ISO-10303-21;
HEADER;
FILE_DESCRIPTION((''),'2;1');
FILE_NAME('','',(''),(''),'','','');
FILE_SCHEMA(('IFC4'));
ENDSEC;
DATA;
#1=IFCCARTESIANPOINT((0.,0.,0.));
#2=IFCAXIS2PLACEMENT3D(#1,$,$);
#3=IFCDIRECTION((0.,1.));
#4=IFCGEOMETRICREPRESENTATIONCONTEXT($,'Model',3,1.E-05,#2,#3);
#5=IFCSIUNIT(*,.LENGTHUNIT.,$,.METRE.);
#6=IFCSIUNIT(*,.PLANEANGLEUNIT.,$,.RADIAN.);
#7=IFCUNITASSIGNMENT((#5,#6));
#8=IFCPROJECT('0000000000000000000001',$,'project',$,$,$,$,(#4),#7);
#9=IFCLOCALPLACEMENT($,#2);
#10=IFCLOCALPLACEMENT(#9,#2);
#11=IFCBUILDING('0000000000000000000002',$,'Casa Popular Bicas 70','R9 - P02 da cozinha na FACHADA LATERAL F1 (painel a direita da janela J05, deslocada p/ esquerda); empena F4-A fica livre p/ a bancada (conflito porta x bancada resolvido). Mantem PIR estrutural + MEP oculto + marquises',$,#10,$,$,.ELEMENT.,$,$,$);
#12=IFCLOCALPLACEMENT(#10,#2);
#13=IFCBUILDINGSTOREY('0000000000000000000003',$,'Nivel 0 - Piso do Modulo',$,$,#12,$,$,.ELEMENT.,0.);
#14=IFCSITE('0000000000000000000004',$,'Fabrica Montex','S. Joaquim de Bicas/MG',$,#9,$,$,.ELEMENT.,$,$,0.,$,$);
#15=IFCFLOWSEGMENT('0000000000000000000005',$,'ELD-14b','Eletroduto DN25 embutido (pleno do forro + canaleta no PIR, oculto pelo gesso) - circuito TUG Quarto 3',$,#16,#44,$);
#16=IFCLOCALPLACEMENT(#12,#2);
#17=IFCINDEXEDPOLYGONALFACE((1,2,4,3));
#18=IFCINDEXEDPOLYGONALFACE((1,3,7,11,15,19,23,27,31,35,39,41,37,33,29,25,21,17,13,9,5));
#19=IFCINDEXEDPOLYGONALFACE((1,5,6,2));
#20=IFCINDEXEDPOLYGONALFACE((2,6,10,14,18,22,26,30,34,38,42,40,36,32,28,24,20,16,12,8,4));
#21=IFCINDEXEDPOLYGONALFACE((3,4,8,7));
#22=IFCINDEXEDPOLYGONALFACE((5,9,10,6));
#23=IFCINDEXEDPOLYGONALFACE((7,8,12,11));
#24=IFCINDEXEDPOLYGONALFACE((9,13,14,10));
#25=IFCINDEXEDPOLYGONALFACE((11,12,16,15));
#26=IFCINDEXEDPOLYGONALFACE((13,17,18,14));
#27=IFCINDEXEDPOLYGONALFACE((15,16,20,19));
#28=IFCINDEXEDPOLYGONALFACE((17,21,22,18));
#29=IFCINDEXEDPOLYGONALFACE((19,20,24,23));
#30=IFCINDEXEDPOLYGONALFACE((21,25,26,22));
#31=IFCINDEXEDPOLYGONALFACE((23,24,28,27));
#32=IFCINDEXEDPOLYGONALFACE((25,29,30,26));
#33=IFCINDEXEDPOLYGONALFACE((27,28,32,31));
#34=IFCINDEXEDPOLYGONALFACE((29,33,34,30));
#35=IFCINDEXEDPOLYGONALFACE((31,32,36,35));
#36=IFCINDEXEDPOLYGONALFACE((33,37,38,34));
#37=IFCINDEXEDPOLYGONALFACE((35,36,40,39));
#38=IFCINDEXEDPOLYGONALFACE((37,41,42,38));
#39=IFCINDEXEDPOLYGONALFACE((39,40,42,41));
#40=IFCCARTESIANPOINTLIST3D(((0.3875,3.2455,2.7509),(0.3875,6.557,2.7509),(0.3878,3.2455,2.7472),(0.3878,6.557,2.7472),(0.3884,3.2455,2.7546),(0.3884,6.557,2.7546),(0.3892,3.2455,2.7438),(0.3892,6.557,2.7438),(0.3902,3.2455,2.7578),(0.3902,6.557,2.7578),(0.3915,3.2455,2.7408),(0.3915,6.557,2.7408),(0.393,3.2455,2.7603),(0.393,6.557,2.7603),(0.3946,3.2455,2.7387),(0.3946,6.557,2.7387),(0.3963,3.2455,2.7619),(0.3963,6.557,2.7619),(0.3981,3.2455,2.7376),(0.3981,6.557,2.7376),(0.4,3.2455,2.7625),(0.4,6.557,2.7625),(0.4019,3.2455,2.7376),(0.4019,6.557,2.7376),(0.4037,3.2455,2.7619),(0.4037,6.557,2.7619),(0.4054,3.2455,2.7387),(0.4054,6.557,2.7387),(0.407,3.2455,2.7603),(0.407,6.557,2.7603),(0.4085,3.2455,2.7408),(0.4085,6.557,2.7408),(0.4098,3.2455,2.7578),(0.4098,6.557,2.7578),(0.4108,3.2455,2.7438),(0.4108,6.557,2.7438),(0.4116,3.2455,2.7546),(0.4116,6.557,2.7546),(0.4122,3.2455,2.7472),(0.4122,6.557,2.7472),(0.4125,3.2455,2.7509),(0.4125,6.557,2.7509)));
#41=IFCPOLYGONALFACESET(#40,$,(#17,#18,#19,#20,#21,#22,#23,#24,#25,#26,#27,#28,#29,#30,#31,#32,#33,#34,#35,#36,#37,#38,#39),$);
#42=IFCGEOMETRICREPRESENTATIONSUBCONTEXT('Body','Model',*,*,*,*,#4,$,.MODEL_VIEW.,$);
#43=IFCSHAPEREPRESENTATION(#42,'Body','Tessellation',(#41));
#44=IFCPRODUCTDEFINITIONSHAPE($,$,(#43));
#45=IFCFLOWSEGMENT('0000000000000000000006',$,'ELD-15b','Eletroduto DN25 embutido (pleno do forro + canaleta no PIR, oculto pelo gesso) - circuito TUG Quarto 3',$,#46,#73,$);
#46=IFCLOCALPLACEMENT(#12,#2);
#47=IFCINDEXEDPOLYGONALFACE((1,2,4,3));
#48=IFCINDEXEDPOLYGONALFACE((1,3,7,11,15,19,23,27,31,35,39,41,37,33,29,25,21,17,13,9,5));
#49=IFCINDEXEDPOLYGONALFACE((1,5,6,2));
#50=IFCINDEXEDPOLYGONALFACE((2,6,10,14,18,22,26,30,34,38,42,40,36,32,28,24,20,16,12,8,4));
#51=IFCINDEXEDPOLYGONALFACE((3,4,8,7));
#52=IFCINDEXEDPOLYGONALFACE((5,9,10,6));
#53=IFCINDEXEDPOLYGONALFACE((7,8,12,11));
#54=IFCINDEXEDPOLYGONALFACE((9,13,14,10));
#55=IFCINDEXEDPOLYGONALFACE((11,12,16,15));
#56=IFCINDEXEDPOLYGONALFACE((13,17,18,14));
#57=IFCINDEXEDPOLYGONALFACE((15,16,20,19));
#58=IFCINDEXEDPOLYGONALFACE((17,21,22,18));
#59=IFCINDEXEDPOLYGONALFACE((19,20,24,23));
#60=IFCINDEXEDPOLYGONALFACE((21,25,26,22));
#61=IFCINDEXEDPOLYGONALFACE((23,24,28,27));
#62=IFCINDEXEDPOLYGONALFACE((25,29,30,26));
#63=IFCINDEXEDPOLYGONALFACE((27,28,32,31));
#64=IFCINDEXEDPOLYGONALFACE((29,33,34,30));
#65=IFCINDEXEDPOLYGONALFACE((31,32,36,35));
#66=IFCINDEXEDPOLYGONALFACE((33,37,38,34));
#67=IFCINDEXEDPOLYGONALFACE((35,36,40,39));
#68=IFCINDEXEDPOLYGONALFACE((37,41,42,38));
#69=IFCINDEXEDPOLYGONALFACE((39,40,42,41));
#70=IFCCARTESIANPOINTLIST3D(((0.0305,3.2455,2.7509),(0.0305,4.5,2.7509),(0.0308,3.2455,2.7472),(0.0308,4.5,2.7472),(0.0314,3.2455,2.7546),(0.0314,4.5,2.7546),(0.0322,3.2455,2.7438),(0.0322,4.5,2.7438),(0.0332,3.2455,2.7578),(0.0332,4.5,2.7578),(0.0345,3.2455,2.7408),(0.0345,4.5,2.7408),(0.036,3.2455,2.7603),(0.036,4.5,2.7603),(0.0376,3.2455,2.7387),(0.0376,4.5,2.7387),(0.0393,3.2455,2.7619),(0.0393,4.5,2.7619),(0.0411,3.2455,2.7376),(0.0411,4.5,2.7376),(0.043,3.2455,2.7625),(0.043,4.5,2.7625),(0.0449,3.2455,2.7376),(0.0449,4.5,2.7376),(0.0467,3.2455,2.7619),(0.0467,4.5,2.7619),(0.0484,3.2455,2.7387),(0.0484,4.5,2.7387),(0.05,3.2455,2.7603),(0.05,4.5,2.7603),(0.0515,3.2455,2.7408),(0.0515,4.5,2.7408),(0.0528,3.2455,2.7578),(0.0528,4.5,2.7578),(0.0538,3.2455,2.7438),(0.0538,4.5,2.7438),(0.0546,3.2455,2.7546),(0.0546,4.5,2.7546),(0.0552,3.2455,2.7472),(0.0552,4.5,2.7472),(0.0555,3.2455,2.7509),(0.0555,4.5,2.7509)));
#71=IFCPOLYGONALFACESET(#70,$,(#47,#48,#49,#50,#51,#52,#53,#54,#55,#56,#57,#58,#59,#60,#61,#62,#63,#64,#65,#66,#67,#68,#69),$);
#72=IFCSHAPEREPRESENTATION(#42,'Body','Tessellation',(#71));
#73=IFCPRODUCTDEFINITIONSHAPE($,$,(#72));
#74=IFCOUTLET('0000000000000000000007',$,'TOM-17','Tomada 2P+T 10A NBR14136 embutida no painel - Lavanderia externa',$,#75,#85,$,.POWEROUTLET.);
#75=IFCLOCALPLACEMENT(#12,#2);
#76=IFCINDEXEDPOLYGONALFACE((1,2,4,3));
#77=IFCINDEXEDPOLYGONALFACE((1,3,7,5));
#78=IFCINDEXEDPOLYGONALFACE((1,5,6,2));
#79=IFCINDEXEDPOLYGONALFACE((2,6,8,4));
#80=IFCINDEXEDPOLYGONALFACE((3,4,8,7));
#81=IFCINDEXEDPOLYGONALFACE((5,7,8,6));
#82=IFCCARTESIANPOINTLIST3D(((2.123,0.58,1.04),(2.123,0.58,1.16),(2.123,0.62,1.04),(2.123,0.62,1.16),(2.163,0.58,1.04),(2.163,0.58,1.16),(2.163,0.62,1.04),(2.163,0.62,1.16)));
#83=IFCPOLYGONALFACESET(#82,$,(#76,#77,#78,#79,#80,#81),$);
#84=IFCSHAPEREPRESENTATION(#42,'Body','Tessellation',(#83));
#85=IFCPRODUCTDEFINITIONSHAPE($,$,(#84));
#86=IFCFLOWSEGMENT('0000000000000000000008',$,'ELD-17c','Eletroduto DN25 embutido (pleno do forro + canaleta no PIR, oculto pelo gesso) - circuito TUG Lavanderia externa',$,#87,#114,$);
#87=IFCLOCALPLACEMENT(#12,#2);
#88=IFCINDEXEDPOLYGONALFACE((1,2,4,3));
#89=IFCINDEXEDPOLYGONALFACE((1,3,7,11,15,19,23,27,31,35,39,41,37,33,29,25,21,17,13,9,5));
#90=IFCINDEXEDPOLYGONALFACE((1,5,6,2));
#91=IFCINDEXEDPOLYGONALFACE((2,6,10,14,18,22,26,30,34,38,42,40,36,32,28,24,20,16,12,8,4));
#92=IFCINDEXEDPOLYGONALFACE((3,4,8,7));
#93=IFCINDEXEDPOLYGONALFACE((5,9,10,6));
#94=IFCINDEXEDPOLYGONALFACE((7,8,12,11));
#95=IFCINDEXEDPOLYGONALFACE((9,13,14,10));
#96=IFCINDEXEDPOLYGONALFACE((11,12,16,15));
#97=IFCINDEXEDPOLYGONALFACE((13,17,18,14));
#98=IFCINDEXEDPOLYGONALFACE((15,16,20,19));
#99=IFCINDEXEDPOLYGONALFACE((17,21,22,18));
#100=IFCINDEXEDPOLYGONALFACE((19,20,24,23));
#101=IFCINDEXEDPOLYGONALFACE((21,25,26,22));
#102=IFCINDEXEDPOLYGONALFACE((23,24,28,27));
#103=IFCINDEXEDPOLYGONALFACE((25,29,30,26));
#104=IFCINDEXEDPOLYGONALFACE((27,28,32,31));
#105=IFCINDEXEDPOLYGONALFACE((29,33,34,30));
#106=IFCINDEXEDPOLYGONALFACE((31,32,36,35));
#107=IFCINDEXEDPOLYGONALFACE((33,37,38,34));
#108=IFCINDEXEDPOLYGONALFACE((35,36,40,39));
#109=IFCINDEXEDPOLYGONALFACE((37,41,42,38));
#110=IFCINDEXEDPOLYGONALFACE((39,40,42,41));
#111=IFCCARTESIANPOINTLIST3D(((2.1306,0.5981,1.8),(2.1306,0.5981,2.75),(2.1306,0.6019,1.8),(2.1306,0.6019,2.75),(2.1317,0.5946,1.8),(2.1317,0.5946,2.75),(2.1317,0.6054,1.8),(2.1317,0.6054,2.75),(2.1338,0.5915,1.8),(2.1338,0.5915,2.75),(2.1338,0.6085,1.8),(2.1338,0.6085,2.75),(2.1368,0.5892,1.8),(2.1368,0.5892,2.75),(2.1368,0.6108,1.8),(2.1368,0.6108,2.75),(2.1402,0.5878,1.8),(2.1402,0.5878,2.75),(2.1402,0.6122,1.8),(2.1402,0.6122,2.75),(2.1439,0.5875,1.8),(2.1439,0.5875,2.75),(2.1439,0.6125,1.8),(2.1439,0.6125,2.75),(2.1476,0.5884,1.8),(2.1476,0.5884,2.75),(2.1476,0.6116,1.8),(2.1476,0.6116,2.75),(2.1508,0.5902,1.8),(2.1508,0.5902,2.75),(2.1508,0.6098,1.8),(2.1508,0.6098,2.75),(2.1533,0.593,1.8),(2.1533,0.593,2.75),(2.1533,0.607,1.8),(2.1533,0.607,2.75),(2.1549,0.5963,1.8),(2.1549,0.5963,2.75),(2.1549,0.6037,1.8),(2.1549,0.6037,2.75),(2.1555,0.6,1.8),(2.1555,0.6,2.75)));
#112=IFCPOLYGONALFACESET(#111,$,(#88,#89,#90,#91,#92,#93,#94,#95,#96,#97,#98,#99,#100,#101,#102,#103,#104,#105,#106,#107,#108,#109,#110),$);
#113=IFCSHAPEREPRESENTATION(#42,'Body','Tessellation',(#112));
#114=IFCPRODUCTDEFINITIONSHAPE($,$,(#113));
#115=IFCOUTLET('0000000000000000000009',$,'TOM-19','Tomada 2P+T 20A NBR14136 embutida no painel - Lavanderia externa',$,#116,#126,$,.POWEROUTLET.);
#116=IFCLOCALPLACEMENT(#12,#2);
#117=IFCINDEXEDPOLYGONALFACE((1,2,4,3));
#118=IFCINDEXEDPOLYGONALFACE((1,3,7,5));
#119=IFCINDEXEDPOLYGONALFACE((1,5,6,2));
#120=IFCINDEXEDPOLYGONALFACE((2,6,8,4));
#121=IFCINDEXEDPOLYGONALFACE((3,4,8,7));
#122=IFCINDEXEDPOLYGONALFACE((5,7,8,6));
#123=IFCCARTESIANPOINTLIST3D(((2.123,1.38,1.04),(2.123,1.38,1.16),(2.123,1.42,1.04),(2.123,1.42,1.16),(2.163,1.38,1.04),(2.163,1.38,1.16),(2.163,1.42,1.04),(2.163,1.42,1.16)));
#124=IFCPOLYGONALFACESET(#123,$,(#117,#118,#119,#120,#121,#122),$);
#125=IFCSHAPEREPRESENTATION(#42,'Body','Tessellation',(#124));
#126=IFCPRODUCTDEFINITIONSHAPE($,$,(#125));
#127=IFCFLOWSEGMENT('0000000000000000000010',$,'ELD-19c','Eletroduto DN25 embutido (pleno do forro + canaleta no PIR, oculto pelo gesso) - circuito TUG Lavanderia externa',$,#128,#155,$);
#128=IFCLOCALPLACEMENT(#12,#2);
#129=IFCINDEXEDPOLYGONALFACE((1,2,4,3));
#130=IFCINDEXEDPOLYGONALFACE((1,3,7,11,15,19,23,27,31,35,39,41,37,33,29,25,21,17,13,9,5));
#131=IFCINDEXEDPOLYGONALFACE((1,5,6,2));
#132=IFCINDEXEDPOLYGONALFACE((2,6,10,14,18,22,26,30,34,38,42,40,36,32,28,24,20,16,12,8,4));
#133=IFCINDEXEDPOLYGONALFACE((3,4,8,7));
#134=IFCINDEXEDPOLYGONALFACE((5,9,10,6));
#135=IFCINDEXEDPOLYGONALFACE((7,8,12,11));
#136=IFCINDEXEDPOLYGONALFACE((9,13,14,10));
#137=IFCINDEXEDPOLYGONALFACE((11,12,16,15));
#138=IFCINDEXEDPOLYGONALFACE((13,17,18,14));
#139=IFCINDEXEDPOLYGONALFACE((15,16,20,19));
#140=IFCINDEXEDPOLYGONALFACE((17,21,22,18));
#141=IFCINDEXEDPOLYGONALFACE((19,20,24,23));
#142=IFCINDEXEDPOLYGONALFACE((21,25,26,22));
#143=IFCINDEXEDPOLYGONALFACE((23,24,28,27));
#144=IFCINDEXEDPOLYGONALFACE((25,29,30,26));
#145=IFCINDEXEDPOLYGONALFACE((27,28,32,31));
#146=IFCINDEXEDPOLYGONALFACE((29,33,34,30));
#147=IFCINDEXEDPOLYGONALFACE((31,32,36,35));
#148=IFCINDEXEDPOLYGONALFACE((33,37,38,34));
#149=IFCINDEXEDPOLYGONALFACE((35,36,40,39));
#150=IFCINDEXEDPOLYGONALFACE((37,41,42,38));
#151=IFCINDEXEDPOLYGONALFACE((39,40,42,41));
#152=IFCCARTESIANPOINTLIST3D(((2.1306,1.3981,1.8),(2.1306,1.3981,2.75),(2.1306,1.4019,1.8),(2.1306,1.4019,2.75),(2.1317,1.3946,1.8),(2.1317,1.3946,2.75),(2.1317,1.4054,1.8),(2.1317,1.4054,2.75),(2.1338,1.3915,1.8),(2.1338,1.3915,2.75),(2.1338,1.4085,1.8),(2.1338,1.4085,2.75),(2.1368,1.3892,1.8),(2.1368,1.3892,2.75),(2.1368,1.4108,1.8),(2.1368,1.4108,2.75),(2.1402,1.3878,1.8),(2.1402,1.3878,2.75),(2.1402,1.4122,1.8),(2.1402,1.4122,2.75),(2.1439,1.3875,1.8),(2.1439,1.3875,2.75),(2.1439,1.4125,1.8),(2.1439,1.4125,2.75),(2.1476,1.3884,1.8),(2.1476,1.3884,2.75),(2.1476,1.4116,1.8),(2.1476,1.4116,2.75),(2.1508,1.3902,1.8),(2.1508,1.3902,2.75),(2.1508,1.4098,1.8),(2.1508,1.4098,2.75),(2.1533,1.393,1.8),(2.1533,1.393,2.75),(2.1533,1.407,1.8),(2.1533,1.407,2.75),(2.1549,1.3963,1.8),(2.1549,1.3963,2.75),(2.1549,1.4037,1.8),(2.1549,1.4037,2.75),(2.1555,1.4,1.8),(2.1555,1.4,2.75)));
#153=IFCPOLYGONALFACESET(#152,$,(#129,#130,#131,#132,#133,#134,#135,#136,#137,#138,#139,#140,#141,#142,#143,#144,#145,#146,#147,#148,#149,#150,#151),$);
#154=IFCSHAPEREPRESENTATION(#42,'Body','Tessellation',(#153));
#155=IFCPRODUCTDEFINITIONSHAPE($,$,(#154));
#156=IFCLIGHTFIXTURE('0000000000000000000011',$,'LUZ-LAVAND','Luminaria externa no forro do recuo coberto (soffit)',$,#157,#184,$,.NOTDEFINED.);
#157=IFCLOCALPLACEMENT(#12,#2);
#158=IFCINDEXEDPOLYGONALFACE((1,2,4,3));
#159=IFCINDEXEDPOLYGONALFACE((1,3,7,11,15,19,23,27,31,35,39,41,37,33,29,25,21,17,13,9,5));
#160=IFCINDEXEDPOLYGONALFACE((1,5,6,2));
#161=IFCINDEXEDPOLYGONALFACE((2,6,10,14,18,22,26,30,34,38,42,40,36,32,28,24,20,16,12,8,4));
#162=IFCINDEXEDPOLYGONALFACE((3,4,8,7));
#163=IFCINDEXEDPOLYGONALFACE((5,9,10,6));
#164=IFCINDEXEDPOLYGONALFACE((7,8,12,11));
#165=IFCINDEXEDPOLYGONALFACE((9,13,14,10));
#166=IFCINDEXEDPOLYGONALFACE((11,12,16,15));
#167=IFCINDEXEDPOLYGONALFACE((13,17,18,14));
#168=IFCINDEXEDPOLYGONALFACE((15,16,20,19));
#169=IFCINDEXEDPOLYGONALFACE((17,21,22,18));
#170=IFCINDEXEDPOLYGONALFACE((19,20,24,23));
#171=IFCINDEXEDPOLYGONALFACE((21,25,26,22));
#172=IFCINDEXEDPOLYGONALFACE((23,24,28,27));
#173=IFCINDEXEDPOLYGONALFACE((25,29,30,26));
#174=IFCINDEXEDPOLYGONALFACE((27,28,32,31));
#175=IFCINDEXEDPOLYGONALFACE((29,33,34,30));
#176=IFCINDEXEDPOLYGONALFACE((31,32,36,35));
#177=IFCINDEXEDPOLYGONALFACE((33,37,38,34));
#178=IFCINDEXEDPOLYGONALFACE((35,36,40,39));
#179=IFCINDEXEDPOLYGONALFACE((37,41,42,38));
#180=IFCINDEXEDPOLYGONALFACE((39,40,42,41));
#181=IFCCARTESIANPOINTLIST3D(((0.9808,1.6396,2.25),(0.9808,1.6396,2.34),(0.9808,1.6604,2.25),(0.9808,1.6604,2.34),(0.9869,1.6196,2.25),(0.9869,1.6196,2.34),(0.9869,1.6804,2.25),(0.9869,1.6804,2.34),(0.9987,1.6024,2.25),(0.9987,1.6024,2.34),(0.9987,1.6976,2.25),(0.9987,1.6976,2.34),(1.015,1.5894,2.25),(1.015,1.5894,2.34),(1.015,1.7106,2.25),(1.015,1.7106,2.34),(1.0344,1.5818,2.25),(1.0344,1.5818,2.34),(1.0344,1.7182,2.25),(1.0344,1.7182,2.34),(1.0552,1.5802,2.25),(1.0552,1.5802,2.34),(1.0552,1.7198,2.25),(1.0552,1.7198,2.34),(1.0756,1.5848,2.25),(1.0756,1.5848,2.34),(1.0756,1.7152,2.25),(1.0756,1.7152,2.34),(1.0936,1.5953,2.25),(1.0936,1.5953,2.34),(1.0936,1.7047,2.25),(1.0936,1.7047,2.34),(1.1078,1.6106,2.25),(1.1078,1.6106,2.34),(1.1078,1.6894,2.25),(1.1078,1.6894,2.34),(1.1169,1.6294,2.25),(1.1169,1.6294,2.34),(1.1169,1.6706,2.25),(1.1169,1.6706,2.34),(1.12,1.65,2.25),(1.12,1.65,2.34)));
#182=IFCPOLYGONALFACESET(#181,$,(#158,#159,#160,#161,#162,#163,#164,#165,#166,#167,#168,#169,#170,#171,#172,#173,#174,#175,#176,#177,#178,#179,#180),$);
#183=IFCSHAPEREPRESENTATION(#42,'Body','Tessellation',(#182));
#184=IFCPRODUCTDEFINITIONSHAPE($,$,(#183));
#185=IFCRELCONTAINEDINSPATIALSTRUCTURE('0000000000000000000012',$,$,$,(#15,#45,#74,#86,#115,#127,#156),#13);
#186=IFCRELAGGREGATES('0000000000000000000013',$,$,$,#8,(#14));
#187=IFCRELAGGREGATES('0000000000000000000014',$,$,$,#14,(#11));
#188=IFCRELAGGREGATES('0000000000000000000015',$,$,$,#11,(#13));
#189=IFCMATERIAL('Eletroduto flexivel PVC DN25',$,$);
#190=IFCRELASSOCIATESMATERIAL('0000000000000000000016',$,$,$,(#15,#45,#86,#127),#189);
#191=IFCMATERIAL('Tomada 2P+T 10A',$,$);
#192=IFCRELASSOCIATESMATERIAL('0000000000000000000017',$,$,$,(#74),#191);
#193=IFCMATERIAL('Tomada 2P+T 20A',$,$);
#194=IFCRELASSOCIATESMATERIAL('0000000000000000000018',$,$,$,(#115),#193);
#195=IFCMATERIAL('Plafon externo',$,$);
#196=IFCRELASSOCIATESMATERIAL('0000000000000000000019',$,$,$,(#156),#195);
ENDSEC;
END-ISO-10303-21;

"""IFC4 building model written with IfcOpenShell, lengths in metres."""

from ifc_helpers import new_model, si_unit, direction, frame, frame_2d, origin, origin_2d, place, context, subcontext, project, spatial, rectangle, circle, extrude, material, element, save


model = new_model("IFC4")

# Units and contexts
model_context = context("Model", 3, precision=1e-05, world=origin(), true_north=direction((0.0, 1.0)))
body_context = subcontext(model_context, "Body", "Model", "MODEL_VIEW")
ifc_project = project(units=[si_unit("LENGTHUNIT", "METRE"), si_unit("PLANEANGLEUNIT", "RADIAN")], contexts=[model_context])

# Site, building, storey
site_placement = place(None, origin())
site = spatial("IfcSite", under=ifc_project, at=site_placement, Name="Fabrica Montex", Description="S. Joaquim de Bicas/MG", CompositionType="ELEMENT", RefElevation=0.0)
building_placement = place(site_placement, origin())
building = spatial("IfcBuilding", under=site, at=building_placement, Name="Casa Popular Bicas 70", Description="R9 - P02 da cozinha na FACHADA LATERAL F1 (painel a direita da janela J05, deslocada p/ esquerda); empena F4-A fica livre p/ a bancada (conflito porta x bancada resolvido). Mantem PIR estrutural + MEP oculto + marquises", CompositionType="ELEMENT")
storey_placement = place(building_placement, origin())
storey = spatial("IfcBuildingStorey", under=building, at=storey_placement, Name="Nivel 0 - Piso do Modulo", CompositionType="ELEMENT", Elevation=0.0)

# Shared definitions
ifc_material_1 = material(Name="Tomada 2P+T 10A")

# Shared definitions
ifc_material_2 = material(Name="Eletroduto flexivel PVC DN25")

# Flow segments
flow_segment_1_placement = place(storey_placement, frame((0.4, 3.2455, 2.75), z_axis=(0.0, 1.0, 0.0), x_axis=(0.0, 0.0, 1.0)))
element("IfcFlowSegment", 1, at=flow_segment_1_placement, inside=storey, material=ifc_material_2, Name="ELD-14b", Description="Eletroduto DN25 embutido (pleno do forro + canaleta no PIR, oculto pelo gesso) - circuito TUG Quarto 3", context=body_context, shape_type="SweptSolid", body=[
    extrude(circle(Radius=0.0125, at=origin_2d()), origin(), (0.0, 0.0, 1.0), 3.3115),
])
flow_segment_2_placement = place(storey_placement, frame((0.043, 3.2455, 2.75), z_axis=(0.0, 1.0, 0.0), x_axis=(0.0, 0.0, 1.0)))
element("IfcFlowSegment", 2, at=flow_segment_2_placement, inside=storey, material=ifc_material_2, Name="ELD-15b", Description="Eletroduto DN25 embutido (pleno do forro + canaleta no PIR, oculto pelo gesso) - circuito TUG Quarto 3", context=body_context, shape_type="SweptSolid", body=[
    extrude(circle(Radius=0.0125, at=origin_2d()), origin(), (0.0, 0.0, 1.0), 1.2545),
])

# Outlet
outlet_1_placement = place(storey_placement, frame((2.123, 0.58, 1.04)))
element("IfcOutlet", 3, at=outlet_1_placement, inside=storey, material=ifc_material_1, Name="TOM-17", Description="Tomada 2P+T 10A NBR14136 embutida no painel - Lavanderia externa", PredefinedType="POWEROUTLET", context=body_context, shape_type="SweptSolid", body=[
    extrude(rectangle(XDim=0.04, YDim=0.04, at=frame_2d((0.02, 0.02))), origin(), (0.0, 0.0, 1.0), 0.12),
])

# Flow segment
flow_segment_3_placement = place(storey_placement, frame((2.143, 0.6, 2.75), z_axis=(0.0, 0.0, -1.0), x_axis=(1.0, 0.0, 0.0)))
element("IfcFlowSegment", 4, at=flow_segment_3_placement, inside=storey, material=ifc_material_2, Name="ELD-17c", Description="Eletroduto DN25 embutido (pleno do forro + canaleta no PIR, oculto pelo gesso) - circuito TUG Lavanderia externa", context=body_context, shape_type="SweptSolid", body=[
    extrude(circle(Radius=0.0125, at=origin_2d()), origin(), (0.0, 0.0, 1.0), 0.95),
])

# Outlet
ifc_material_3 = material(Name="Tomada 2P+T 20A")
outlet_2_placement = place(storey_placement, frame((2.123, 1.38, 1.04)))
element("IfcOutlet", 5, at=outlet_2_placement, inside=storey, material=ifc_material_3, Name="TOM-19", Description="Tomada 2P+T 20A NBR14136 embutida no painel - Lavanderia externa", PredefinedType="POWEROUTLET", context=body_context, shape_type="SweptSolid", body=[
    extrude(rectangle(XDim=0.04, YDim=0.04, at=frame_2d((0.02, 0.02))), origin(), (0.0, 0.0, 1.0), 0.12),
])

# Flow segment
flow_segment_4_placement = place(storey_placement, frame((2.143, 1.4, 2.75), z_axis=(0.0, 0.0, -1.0), x_axis=(1.0, 0.0, 0.0)))
element("IfcFlowSegment", 6, at=flow_segment_4_placement, inside=storey, material=ifc_material_2, Name="ELD-19c", Description="Eletroduto DN25 embutido (pleno do forro + canaleta no PIR, oculto pelo gesso) - circuito TUG Lavanderia externa", context=body_context, shape_type="SweptSolid", body=[
    extrude(circle(Radius=0.0125, at=origin_2d()), origin(), (0.0, 0.0, 1.0), 0.95),
])

# Light fixture
ifc_material_4 = material(Name="Plafon externo")
light_fixture_placement = place(storey_placement, frame((1.05, 1.65, 2.25)))
element("IfcLightFixture", 7, at=light_fixture_placement, inside=storey, material=ifc_material_4, Name="LUZ-LAVAND", Description="Luminaria externa no forro do recuo coberto (soffit)", PredefinedType="NOTDEFINED", context=body_context, shape_type="SweptSolid", body=[
    extrude(circle(Radius=0.07, at=origin_2d()), origin(), (0.0, 0.0, 1.0), 0.09),
])

save(model, "model.ifc")
